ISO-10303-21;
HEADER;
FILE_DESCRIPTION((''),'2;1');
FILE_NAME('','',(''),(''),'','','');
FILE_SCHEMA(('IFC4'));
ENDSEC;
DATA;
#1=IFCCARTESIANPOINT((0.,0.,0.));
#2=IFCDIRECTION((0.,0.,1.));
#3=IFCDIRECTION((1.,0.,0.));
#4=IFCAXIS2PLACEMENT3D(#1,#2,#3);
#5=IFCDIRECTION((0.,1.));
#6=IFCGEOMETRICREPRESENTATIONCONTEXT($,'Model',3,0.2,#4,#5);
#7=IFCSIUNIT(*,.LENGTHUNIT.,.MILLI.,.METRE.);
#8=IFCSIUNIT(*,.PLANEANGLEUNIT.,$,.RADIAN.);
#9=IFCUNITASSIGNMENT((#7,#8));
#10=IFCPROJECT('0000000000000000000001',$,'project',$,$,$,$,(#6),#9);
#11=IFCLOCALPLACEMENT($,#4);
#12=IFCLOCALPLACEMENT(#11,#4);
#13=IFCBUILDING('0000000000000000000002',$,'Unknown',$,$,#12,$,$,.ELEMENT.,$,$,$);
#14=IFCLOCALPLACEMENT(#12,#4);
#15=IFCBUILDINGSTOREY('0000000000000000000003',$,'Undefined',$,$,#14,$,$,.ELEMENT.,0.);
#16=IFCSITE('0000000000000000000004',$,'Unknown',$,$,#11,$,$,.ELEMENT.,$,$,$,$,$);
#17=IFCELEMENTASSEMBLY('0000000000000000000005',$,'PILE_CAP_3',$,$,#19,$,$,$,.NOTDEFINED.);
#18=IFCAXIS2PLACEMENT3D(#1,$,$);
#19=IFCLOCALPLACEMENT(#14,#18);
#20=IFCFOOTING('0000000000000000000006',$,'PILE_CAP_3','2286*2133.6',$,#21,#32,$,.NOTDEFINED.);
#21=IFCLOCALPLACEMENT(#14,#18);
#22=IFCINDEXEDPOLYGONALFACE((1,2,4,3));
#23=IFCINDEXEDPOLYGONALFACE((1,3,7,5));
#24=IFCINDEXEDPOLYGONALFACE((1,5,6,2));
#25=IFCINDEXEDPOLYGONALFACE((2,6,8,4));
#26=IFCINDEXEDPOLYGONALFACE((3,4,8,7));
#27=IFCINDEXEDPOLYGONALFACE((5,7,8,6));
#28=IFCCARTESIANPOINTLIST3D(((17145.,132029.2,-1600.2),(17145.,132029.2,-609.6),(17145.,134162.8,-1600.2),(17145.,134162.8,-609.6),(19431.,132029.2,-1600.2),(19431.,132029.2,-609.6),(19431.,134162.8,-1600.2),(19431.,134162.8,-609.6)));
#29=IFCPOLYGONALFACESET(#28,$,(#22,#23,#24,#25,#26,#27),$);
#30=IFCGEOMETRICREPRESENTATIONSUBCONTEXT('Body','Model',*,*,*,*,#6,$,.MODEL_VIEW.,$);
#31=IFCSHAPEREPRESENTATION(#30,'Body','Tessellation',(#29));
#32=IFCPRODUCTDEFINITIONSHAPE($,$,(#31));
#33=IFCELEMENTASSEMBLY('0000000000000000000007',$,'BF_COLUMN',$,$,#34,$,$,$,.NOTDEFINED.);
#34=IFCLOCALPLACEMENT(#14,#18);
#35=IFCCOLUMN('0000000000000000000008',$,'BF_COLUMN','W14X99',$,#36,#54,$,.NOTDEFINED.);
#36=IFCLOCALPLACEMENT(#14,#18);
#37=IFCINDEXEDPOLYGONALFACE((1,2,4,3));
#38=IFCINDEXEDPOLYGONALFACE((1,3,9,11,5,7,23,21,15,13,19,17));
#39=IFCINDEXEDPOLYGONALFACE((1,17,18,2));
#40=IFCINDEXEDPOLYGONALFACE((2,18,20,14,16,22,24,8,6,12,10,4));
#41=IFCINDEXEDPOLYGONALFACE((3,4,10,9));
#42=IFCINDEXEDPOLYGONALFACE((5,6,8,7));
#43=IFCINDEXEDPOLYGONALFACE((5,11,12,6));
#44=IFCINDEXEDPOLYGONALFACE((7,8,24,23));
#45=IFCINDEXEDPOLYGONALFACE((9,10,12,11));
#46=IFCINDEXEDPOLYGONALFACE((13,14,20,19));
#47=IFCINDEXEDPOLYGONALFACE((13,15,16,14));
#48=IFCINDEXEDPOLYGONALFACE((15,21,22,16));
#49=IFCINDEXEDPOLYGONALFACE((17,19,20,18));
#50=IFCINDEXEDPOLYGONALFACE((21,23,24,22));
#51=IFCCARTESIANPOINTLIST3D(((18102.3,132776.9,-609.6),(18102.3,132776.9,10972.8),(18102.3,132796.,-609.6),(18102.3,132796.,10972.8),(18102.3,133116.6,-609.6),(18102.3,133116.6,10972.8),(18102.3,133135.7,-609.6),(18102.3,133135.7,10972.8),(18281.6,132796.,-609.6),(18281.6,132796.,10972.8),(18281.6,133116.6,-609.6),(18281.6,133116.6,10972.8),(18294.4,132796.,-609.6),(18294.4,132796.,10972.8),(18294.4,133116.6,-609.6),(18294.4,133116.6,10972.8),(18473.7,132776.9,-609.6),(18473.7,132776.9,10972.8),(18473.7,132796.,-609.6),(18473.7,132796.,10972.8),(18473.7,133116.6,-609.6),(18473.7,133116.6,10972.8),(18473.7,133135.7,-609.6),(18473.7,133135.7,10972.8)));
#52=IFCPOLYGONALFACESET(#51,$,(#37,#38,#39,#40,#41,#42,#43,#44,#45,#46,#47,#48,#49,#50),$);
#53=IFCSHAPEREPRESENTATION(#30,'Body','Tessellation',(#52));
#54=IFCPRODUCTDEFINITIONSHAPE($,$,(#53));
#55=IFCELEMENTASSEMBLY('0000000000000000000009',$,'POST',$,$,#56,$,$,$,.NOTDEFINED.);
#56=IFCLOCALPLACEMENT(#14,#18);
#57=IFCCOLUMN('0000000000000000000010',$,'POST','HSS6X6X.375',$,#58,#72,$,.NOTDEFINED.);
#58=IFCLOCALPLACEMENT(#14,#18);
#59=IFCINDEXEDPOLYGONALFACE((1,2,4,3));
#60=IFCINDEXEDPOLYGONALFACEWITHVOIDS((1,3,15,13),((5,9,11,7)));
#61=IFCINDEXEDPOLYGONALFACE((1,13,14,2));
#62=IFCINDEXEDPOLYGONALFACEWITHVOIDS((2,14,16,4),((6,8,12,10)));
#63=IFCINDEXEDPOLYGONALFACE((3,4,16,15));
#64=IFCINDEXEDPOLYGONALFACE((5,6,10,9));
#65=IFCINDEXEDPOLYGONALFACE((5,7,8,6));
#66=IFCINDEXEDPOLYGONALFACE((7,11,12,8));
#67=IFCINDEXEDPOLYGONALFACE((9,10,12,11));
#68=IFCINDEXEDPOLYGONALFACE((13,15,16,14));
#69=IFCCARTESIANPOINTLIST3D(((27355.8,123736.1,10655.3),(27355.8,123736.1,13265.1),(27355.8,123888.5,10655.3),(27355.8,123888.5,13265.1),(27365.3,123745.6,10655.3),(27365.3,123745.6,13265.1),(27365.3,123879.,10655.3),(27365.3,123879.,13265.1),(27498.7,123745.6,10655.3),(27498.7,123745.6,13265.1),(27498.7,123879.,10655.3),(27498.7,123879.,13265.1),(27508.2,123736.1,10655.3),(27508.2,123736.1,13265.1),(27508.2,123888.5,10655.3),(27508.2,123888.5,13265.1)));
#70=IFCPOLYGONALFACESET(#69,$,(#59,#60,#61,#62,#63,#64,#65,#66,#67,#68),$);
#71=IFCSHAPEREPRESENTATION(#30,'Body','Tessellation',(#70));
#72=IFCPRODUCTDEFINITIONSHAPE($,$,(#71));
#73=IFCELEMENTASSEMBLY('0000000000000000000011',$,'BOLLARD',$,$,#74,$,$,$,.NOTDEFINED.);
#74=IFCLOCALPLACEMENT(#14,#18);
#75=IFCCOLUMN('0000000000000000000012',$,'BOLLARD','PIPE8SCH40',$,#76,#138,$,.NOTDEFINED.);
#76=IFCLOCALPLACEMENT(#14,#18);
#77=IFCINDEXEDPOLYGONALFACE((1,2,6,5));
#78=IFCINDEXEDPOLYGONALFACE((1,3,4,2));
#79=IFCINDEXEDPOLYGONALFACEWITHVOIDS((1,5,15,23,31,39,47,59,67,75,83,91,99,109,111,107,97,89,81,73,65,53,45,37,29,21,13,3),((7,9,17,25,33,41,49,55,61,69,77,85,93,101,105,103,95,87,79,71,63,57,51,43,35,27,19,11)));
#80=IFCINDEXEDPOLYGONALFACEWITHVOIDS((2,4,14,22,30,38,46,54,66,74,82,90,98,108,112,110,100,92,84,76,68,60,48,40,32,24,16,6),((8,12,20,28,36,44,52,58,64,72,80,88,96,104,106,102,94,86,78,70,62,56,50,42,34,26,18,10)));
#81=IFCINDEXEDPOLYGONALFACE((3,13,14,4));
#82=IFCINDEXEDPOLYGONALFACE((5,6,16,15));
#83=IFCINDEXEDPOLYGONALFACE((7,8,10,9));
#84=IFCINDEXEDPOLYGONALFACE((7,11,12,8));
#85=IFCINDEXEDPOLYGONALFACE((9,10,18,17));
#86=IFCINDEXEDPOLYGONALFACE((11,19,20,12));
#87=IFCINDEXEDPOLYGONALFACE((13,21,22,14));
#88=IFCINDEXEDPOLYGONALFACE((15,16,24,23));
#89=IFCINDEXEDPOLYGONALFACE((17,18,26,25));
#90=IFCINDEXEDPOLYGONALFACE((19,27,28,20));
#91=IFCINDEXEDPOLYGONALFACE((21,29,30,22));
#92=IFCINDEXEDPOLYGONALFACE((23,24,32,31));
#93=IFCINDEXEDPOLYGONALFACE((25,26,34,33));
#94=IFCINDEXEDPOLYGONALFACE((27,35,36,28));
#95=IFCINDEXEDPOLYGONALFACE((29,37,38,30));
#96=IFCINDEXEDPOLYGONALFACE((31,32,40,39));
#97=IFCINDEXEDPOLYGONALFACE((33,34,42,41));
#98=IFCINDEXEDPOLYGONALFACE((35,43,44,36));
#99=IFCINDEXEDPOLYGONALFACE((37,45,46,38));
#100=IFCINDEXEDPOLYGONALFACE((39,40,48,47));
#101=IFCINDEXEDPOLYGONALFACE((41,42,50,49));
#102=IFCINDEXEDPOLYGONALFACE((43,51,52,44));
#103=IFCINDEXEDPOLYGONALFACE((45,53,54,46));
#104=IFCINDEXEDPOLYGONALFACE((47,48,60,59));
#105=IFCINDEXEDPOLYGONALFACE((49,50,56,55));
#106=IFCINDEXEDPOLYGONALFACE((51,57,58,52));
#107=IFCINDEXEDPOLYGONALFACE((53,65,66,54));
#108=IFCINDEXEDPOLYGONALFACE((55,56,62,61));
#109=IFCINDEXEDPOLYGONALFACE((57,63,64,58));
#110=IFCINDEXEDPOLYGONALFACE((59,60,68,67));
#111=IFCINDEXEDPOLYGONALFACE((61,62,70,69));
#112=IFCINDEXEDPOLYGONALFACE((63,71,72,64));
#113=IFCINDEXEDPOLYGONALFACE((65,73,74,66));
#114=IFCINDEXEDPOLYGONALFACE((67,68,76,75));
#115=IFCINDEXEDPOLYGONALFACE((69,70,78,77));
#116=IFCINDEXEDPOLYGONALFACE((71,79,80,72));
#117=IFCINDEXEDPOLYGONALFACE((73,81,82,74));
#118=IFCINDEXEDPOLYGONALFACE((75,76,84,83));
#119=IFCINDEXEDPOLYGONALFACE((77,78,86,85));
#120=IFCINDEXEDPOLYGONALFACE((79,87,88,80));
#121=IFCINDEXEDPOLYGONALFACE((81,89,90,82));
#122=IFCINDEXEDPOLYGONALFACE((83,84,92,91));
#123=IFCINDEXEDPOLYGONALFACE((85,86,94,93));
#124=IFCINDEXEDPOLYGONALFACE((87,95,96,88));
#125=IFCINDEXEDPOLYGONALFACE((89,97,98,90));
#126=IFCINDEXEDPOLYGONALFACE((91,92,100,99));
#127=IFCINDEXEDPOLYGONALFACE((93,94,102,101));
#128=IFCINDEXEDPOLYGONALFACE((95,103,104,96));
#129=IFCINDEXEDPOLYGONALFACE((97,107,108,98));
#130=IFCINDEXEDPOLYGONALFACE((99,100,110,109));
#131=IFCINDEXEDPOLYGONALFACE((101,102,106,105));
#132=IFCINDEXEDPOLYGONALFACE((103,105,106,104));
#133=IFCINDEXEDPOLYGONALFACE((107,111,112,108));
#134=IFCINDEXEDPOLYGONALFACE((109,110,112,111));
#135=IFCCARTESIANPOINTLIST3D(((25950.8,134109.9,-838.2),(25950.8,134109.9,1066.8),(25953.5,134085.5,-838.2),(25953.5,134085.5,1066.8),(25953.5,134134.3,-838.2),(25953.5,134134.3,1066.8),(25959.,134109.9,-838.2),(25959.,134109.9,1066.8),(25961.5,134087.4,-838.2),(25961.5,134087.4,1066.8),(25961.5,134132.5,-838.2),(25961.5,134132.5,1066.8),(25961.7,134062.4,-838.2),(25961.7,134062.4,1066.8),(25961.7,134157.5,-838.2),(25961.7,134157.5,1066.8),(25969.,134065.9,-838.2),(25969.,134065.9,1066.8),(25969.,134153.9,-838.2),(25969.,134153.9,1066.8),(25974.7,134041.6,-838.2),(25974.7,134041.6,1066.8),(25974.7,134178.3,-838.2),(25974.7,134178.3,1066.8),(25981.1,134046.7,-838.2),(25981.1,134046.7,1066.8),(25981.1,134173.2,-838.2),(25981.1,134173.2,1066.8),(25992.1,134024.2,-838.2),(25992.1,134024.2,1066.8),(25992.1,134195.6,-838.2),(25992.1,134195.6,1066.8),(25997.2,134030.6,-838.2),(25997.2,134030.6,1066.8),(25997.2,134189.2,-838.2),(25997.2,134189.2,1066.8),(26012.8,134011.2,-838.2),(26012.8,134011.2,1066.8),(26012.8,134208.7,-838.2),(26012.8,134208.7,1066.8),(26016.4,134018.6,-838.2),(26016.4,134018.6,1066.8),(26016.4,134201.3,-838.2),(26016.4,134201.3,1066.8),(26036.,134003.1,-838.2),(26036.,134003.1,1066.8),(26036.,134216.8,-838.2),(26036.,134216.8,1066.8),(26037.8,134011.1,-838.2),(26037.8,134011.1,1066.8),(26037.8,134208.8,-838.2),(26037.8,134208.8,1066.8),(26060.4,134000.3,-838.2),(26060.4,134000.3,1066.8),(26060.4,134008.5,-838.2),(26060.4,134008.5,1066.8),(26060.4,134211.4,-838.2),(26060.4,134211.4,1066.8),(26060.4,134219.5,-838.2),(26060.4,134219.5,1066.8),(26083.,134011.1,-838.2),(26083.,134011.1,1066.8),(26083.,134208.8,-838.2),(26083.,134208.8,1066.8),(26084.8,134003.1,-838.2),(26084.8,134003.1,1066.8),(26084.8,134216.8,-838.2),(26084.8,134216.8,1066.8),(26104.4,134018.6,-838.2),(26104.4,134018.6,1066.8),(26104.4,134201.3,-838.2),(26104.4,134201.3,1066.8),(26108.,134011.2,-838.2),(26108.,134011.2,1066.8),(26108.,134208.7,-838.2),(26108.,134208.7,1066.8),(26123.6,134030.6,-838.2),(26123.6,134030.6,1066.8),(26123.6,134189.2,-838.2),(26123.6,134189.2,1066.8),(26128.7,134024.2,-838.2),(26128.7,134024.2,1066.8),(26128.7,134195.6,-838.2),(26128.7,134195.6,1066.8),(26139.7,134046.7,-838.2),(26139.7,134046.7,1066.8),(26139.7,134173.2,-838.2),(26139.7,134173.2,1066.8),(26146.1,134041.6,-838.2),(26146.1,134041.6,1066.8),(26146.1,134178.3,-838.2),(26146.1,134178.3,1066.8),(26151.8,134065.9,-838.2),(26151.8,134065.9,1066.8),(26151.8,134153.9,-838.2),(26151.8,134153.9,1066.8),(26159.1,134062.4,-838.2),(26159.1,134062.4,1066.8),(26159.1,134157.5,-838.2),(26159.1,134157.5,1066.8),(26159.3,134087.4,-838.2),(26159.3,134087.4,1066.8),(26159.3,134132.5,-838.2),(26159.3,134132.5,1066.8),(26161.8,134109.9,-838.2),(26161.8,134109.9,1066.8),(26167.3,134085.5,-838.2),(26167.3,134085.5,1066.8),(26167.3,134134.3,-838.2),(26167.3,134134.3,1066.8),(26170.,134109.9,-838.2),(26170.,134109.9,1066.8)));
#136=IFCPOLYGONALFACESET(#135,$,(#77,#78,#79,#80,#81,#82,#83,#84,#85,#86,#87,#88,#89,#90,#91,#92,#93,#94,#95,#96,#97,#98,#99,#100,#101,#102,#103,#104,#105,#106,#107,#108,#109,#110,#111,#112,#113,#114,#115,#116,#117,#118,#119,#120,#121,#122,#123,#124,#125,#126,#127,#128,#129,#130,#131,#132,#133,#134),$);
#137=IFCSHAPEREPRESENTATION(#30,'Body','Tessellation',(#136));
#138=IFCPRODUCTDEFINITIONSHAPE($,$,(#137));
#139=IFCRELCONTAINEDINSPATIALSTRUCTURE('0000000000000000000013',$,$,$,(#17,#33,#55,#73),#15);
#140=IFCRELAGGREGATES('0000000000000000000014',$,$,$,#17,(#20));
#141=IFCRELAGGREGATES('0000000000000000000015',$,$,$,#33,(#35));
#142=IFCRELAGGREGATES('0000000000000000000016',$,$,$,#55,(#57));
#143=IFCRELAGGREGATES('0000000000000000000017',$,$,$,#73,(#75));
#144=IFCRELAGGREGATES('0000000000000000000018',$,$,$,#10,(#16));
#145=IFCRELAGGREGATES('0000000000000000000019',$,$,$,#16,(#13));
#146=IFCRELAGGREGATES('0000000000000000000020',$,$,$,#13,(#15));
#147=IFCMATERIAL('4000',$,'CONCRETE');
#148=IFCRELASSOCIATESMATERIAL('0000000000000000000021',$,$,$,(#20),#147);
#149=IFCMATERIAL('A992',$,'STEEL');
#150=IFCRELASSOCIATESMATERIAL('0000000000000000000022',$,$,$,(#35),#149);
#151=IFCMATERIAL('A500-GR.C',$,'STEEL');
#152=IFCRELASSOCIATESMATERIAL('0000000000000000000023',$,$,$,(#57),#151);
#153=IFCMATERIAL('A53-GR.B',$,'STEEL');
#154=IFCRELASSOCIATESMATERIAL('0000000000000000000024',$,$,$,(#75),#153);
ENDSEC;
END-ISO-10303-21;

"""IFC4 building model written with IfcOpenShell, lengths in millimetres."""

from ifc_helpers import new_model, si_unit, direction, frame, origin_with_axes, place, context, subcontext, project, spatial, line, indexed_curve, outline, extrude, material, element, aggregate, save


model = new_model("IFC4")

# Units and contexts
model_context = context("Model", 3, precision=0.2, world=origin_with_axes(), true_north=direction((0.0, 1.0)))
body_context = subcontext(model_context, "Body", "Model", "MODEL_VIEW")
ifc_project = project(units=[si_unit("LENGTHUNIT", "METRE", prefix="MILLI"), si_unit("PLANEANGLEUNIT", "RADIAN")], contexts=[model_context])

# Site, building, storey
site_placement = place(None, origin_with_axes())
site = spatial("IfcSite", under=ifc_project, at=site_placement, Name="Unknown", CompositionType="ELEMENT")
building_placement = place(site_placement, origin_with_axes())
building = spatial("IfcBuilding", under=site, at=building_placement, Name="Unknown", CompositionType="ELEMENT")
storey_placement = place(building_placement, origin_with_axes())
storey = spatial("IfcBuildingStorey", under=building, at=storey_placement, Name="Undefined", CompositionType="ELEMENT", Elevation=0.0)

# Element assembly, footing
assembly_1_placement = place(storey_placement, frame((18288.0, 133096.0, -1600.2), z_axis=(0.0, 1.0, 0.0), x_axis=(0.0, 0.0, 1.0)))
assembly_1 = element("IfcElementAssembly", 1, at=assembly_1_placement, inside=storey, Name="PILE_CAP_3", PredefinedType="NOTDEFINED")
ifc_material_1 = material(Name="4000", Category="CONCRETE")
footing_placement = place(assembly_1_placement, origin_with_axes())
footing = element("IfcFooting", 2, at=footing_placement, material=ifc_material_1, Name="PILE_CAP_3", Description="2286*2133.6", PredefinedType="NOTDEFINED", context=body_context, shape_type="SolidModel", body=[
    extrude(outline(indexed_curve([(-1066.8, -1143.0), (1066.8, -1143.0), (1066.8, 1143.0), (-1066.8, 1143.0)], segments=[line(1, 2, 3, 4, 1)])), frame((0.0, 0.0, 0.0), z_axis=(-1.0, 0.0, 0.0), x_axis=(0.0, 0.0, 1.0)), (0.0, 0.0, -1.0), 990.6),
])
aggregate(assembly_1, [footing])

# Element assemblies, columns
assembly_2_placement = place(storey_placement, frame((18288.0, 132956.3, -609.6), z_axis=(-1.0, 0.0, 0.0), x_axis=(0.0, 0.0, 1.0)))
assembly_2 = element("IfcElementAssembly", 3, at=assembly_2_placement, inside=storey, Name="BF_COLUMN", PredefinedType="NOTDEFINED")
ifc_material_2 = material(Name="A992", Category="STEEL")
column_1_placement = place(assembly_2_placement, origin_with_axes())
column_1 = element("IfcColumn", 4, at=column_1_placement, material=ifc_material_2, Name="BF_COLUMN", Description="W14X99", PredefinedType="NOTDEFINED", context=body_context, shape_type="SolidModel", body=[
    extrude(outline(indexed_curve([(-185.7, -179.4), (185.7, -179.4), (185.7, -160.3), (6.3, -160.3), (6.3, 160.3), (185.7, 160.3), (185.7, 179.4), (-185.7, 179.4), (-185.7, 160.3), (-6.3, 160.3), (-6.3, -160.3), (-185.7, -160.3)], segments=[line(1, 2, 3, 4, 5, 6, 7, 8, 9, 10, 11, 12, 1)])), frame((0.0, 0.0, 0.0), z_axis=(-1.0, 0.0, 0.0), x_axis=(0.0, 0.0, 1.0)), (0.0, 0.0, -1.0), 11582.4),
])
aggregate(assembly_2, [column_1])
assembly_3_placement = place(storey_placement, frame((27432.0, 123812.3, 10655.3), z_axis=(0.0, -1.0, 0.0), x_axis=(0.0, 0.0, 1.0)))
assembly_3 = element("IfcElementAssembly", 5, at=assembly_3_placement, inside=storey, Name="POST", PredefinedType="NOTDEFINED")
ifc_material_3 = material(Name="A500-GR.C", Category="STEEL")
column_2_placement = place(assembly_3_placement, origin_with_axes())
column_2 = element("IfcColumn", 6, at=column_2_placement, material=ifc_material_3, Name="POST", Description="HSS6X6X.375", PredefinedType="NOTDEFINED", context=body_context, shape_type="SolidModel", body=[
    extrude(outline(indexed_curve([(-76.2, -76.2), (76.2, -76.2), (76.2, 76.2), (-76.2, 76.2)], segments=[line(1, 2, 3, 4, 1)]), holes=[indexed_curve([(-66.7, -66.7), (-66.7, 66.7), (66.7, 66.7), (66.7, -66.7)], segments=[line(1, 2, 3, 4, 1)])]), frame((0.0, 0.0, 0.0), z_axis=(-1.0, 0.0, 0.0), x_axis=(0.0, 0.0, 1.0)), (0.0, 0.0, -1.0), 2609.8),
])
aggregate(assembly_3, [column_2])
assembly_4_placement = place(storey_placement, frame((26060.4, 134109.9, -838.2), z_axis=(-1.0, 0.0, 0.0), x_axis=(0.0, 0.0, 1.0)))
assembly_4 = element("IfcElementAssembly", 7, at=assembly_4_placement, inside=storey, Name="BOLLARD", PredefinedType="NOTDEFINED")
ifc_material_4 = material(Name="A53-GR.B", Category="STEEL")
column_3_placement = place(assembly_4_placement, origin_with_axes())
column_3 = element("IfcColumn", 8, at=column_3_placement, material=ifc_material_4, Name="BOLLARD", Description="PIPE8SCH40", PredefinedType="NOTDEFINED", context=body_context, shape_type="SolidModel", body=[
    extrude(outline(indexed_curve([(109.6, 0.0), (106.9, 24.4), (98.7, 47.6), (85.7, 68.3), (68.3, 85.7), (47.6, 98.7), (24.4, 106.9), (0.0, 109.6), (-24.4, 106.9), (-47.6, 98.7), (-68.3, 85.7), (-85.7, 68.3), (-98.7, 47.6), (-106.9, 24.4), (-109.6, 0.0), (-106.9, -24.4), (-98.7, -47.6), (-85.7, -68.3), (-68.3, -85.7), (-47.6, -98.7), (-24.4, -106.9), (0.0, -109.6), (24.4, -106.9), (47.6, -98.7), (68.3, -85.7), (85.7, -68.3), (98.7, -47.6), (106.9, -24.4)], segments=[line(1, 2, 3, 4, 5, 6, 7, 8, 9, 10, 11, 12, 13, 14, 15, 16, 17, 18, 19, 20, 21, 22, 23, 24, 25, 26, 27, 28, 1)]), holes=[indexed_curve([(101.4, 0.0), (98.9, -22.6), (91.4, -44.0), (79.3, -63.2), (63.2, -79.3), (44.0, -91.4), (22.6, -98.9), (0.0, -101.4), (-22.6, -98.9), (-44.0, -91.4), (-63.2, -79.3), (-79.3, -63.2), (-91.4, -44.0), (-98.9, -22.6), (-101.4, 0.0), (-98.9, 22.6), (-91.4, 44.0), (-79.3, 63.2), (-63.2, 79.3), (-44.0, 91.4), (-22.6, 98.9), (0.0, 101.4), (22.6, 98.9), (44.0, 91.4), (63.2, 79.3), (79.3, 63.2), (91.4, 44.0), (98.9, 22.6)], segments=[line(1, 2, 3, 4, 5, 6, 7, 8, 9, 10, 11, 12, 13, 14, 15, 16, 17, 18, 19, 20, 21, 22, 23, 24, 25, 26, 27, 28, 1)])]), frame((0.0, 0.0, 0.0), z_axis=(-1.0, 0.0, 0.0), x_axis=(0.0, 0.0, 1.0)), (0.0, 0.0, -1.0), 1905.0),
])
aggregate(assembly_4, [column_3])

save(model, "model.ifc")
